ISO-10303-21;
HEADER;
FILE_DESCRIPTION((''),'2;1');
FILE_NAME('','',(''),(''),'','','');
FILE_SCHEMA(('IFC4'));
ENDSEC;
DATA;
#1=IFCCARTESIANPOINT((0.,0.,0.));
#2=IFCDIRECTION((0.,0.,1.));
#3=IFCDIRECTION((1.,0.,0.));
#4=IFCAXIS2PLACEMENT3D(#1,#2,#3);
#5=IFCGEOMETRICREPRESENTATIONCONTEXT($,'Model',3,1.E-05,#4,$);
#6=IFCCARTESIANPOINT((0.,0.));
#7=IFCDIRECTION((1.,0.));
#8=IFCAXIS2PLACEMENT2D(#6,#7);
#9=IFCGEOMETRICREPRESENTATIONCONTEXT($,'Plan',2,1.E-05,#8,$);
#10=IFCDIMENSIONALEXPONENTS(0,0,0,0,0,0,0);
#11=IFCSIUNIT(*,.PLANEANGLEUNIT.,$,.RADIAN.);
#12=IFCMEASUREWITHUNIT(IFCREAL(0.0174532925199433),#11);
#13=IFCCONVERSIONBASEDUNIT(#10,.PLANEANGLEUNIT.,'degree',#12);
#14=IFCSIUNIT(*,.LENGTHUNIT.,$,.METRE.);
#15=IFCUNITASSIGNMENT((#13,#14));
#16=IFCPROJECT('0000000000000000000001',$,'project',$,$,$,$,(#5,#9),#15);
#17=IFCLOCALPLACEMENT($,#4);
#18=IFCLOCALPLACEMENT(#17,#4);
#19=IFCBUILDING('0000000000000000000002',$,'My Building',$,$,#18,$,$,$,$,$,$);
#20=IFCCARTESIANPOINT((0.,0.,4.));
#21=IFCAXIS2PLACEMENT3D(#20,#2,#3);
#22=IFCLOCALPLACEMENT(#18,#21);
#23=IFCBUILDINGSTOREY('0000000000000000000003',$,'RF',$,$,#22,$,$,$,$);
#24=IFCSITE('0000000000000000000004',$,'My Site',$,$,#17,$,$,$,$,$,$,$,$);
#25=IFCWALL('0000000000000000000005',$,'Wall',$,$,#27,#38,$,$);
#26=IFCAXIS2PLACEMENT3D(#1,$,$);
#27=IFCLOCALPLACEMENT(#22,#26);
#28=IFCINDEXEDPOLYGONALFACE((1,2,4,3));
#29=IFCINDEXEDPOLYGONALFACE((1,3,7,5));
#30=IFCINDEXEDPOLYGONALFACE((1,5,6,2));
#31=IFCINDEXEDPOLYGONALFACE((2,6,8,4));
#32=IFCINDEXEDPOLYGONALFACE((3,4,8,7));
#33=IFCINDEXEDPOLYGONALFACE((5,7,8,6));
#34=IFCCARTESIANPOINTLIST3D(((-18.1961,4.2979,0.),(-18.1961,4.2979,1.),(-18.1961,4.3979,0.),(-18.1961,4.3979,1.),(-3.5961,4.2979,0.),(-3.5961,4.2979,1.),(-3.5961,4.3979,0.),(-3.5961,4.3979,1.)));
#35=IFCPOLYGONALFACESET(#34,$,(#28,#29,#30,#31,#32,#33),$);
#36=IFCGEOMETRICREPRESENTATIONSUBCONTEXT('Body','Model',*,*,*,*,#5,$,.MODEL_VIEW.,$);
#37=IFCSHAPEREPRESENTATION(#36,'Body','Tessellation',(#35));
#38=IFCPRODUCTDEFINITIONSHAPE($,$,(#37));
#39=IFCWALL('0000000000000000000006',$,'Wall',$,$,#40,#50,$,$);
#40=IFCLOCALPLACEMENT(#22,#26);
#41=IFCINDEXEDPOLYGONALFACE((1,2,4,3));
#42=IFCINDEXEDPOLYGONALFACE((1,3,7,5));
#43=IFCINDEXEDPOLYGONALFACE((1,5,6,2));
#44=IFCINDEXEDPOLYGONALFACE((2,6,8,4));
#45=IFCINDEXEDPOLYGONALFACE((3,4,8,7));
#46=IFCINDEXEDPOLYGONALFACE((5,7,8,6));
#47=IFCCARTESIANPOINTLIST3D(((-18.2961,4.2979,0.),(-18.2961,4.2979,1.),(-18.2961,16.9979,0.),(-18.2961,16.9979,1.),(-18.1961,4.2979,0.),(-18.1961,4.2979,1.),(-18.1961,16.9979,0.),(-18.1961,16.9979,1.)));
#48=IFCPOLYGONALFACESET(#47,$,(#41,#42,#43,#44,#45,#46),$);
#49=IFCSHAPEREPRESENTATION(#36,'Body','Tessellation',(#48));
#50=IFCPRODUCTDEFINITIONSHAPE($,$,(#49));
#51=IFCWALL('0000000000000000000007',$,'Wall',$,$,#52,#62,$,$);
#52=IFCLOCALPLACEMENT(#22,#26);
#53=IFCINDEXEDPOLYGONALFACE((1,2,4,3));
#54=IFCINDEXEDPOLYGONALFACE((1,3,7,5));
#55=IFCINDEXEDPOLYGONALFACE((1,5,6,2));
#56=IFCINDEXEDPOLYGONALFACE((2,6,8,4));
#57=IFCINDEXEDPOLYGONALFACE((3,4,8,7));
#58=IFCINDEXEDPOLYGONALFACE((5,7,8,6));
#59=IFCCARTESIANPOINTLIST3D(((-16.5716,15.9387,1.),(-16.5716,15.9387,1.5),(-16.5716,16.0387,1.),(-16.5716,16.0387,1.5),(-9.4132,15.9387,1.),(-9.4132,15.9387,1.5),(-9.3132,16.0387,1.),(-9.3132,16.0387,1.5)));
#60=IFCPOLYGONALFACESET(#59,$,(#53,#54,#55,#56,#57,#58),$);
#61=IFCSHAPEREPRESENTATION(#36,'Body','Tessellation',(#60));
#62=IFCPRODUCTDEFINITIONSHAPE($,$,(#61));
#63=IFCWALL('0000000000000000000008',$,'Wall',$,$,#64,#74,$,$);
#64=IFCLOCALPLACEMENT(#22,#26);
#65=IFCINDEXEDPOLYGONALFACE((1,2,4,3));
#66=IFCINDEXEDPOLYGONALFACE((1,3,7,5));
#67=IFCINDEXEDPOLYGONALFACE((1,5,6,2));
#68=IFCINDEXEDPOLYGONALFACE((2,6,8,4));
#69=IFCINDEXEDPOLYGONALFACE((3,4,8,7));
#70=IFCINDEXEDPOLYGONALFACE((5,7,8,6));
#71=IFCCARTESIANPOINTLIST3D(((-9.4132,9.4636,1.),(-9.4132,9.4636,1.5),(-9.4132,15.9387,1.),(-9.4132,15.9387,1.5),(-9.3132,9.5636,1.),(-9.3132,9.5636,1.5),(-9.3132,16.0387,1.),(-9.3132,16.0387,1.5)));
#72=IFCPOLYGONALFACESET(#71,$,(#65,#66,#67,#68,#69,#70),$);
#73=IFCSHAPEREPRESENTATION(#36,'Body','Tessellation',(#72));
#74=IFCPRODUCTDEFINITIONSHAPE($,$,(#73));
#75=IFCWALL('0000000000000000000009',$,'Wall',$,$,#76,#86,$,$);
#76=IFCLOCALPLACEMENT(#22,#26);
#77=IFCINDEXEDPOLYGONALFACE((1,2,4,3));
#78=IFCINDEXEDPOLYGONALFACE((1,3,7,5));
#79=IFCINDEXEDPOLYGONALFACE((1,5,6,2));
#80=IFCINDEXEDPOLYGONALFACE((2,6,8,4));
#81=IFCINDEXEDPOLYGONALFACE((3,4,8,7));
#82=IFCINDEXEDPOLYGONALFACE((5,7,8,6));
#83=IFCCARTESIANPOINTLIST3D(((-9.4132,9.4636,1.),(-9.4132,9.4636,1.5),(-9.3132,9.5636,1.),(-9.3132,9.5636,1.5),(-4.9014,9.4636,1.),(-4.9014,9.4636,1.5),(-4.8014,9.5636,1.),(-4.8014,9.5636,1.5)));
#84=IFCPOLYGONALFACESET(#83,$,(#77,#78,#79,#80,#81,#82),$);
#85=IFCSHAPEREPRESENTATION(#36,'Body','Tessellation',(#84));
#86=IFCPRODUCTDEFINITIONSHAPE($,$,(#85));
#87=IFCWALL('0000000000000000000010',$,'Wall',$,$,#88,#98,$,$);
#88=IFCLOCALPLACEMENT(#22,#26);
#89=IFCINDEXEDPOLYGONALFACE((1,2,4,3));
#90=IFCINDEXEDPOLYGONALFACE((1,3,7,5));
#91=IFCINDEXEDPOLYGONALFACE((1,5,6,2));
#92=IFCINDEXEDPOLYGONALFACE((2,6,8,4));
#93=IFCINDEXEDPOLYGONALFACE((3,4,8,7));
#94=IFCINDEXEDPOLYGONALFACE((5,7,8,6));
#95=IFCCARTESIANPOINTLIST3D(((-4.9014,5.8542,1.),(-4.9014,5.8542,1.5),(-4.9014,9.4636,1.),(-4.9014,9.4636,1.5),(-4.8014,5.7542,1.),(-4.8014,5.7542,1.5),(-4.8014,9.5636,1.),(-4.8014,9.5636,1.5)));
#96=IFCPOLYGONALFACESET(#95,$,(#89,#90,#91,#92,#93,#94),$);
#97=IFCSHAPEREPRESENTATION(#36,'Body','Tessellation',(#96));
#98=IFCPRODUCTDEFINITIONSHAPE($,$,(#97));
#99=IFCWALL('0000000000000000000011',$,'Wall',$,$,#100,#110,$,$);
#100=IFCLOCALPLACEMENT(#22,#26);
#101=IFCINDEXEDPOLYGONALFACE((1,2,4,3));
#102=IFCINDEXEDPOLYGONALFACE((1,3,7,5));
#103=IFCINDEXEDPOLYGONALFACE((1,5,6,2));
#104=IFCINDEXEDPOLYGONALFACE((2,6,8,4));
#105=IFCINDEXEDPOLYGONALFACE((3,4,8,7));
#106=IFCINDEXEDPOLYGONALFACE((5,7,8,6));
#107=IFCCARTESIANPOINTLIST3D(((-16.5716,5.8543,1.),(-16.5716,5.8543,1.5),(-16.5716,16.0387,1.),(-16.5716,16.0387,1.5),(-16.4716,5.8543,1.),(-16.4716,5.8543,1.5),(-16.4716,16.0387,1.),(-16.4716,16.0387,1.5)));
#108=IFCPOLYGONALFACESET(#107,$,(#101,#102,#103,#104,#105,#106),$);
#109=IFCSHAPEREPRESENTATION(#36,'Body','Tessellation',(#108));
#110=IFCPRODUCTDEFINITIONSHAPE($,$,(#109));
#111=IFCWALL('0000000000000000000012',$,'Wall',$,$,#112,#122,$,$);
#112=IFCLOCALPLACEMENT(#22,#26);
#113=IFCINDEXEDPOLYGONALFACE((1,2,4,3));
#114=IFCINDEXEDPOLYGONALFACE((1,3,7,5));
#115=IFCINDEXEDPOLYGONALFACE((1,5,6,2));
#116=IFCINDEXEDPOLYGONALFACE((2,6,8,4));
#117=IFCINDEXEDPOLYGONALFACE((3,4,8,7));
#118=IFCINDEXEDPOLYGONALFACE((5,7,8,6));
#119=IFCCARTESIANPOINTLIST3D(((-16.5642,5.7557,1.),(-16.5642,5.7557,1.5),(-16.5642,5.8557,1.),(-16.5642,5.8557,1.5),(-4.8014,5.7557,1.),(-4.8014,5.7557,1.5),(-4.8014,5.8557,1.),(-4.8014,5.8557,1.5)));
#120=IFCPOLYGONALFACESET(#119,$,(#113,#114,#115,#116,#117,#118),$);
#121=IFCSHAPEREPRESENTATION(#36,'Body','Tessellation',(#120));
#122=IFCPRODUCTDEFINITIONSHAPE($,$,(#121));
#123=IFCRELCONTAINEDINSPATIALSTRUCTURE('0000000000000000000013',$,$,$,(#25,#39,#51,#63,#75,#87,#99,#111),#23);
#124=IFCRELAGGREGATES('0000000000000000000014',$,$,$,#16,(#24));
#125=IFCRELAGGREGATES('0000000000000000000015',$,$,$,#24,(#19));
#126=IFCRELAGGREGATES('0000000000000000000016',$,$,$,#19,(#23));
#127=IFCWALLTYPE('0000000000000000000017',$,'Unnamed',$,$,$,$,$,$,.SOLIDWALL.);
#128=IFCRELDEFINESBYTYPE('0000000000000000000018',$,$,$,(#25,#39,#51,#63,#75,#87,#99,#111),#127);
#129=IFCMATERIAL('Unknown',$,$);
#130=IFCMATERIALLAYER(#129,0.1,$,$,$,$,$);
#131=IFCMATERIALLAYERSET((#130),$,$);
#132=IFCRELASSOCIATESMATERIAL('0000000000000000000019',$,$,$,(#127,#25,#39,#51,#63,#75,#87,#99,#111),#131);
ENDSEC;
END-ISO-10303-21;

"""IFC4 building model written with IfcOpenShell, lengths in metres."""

from ifc_helpers import new_model, entity, si_unit, converted_unit, frame, origin_with_axes, origin_2d_with_axis, place, context, subcontext, project, spatial, line, indexed_curve, outline, extrude, material, layer, layer_set, layer_usage, type_object, element, save


model = new_model("IFC4")

# Units and contexts
model_context = context("Model", 3, precision=1e-05, world=origin_with_axes())
plan_context = context("Plan", 2, precision=1e-05, world=origin_2d_with_axis())
body_context = subcontext(model_context, "Body", "Model", "MODEL_VIEW")
ifc_project = project(units=[converted_unit("PLANEANGLEUNIT", "degree", entity("IfcReal", 0.0174532925199433), si_unit("PLANEANGLEUNIT", "RADIAN"), dimensions=[0, 0, 0, 0, 0, 0, 0]), si_unit("LENGTHUNIT", "METRE")], contexts=[model_context, plan_context])

# Site, building, storey
site_placement = place(None, origin_with_axes())
site = spatial("IfcSite", under=ifc_project, at=site_placement, Name="My Site")
building_placement = place(site_placement, origin_with_axes())
building = spatial("IfcBuilding", under=site, at=building_placement, Name="My Building")
storey_placement = place(building_placement, frame((0.0, 0.0, 4.0), z_axis=(0.0, 0.0, 1.0), x_axis=(1.0, 0.0, 0.0)))
storey = spatial("IfcBuildingStorey", under=building, at=storey_placement, Name="RF")

# Shared definitions
ifc_material = material(Name="Unknown")

# Walls
ifc_layer_1 = layer(ifc_material, 0.1)
ifc_layer_set_1 = layer_set([ifc_layer_1])
wall_type = type_object("IfcWallType", Name="Unnamed", PredefinedType="SOLIDWALL", material=ifc_layer_set_1)
ifc_layer_usage_1 = layer_usage(ifc_layer_set_1, "AXIS2", "POSITIVE", 0.0)
wall_1_placement = place(storey_placement, frame((-18.1961, 4.2979, 0.0), z_axis=(0.0, 0.0, 1.0), x_axis=(1.0, 0.0, 0.0)))
element("IfcWall", 1, at=wall_1_placement, inside=storey, type_object=wall_type, material=ifc_layer_usage_1, Name="Wall", context=body_context, shape_type="SweptSolid", body=[
    extrude(outline(indexed_curve([(0.0, 0.0), (0.0, 0.1), (14.6, 0.1), (14.6, 0.0)], segments=[line(1, 2, 3, 4, 1)])), origin_with_axes(), (0.0, 0.0, 1.0), 1.0),
])
ifc_layer_usage_2 = layer_usage(ifc_layer_set_1, "AXIS2", "POSITIVE", 0.0)
wall_2_placement = place(storey_placement, frame((-18.2961, 16.9979, 0.0), z_axis=(0.0, 0.0, 1.0), x_axis=(0.0, -1.0, 0.0)))
element("IfcWall", 2, at=wall_2_placement, inside=storey, type_object=wall_type, material=ifc_layer_usage_2, Name="Wall", context=body_context, shape_type="SweptSolid", body=[
    extrude(outline(indexed_curve([(0.0, 0.0), (0.0, 0.1), (12.7, 0.1), (12.7, 0.0)], segments=[line(1, 2, 3, 4, 1)])), origin_with_axes(), (0.0, 0.0, 1.0), 1.0),
])
ifc_layer_usage_3 = layer_usage(ifc_layer_set_1, "AXIS2", "POSITIVE", 0.0)
wall_3_placement = place(storey_placement, frame((-16.5716, 15.9387, 1.0), z_axis=(0.0, 0.0, 1.0), x_axis=(1.0, 0.0, 0.0)))
element("IfcWall", 3, at=wall_3_placement, inside=storey, type_object=wall_type, material=ifc_layer_usage_3, Name="Wall", context=body_context, shape_type="SweptSolid", body=[
    extrude(outline(indexed_curve([(0.0, 0.0), (0.0, 0.1), (7.2584, 0.1), (7.1584, 0.0)], segments=[line(1, 2, 3, 4, 1)])), origin_with_axes(), (0.0, 0.0, 1.0), 0.5),
])
ifc_layer_usage_4 = layer_usage(ifc_layer_set_1, "AXIS2", "POSITIVE", 0.0)
wall_4_placement = place(storey_placement, frame((-9.4132, 15.9387, 1.0), z_axis=(0.0, 0.0, 1.0), x_axis=(0.0, -1.0, 0.0)))
element("IfcWall", 4, at=wall_4_placement, inside=storey, type_object=wall_type, material=ifc_layer_usage_4, Name="Wall", context=body_context, shape_type="SweptSolid", body=[
    extrude(outline(indexed_curve([(0.0, 0.0), (-0.1, 0.1), (6.3751, 0.1), (6.4751, 0.0)], segments=[line(1, 2, 3, 4, 1)])), origin_with_axes(), (0.0, 0.0, 1.0), 0.5),
])
ifc_layer_usage_5 = layer_usage(ifc_layer_set_1, "AXIS2", "POSITIVE", 0.0)
wall_5_placement = place(storey_placement, frame((-9.4132, 9.4636, 1.0), z_axis=(0.0, 0.0, 1.0), x_axis=(1.0, 0.0, 0.0)))
element("IfcWall", 5, at=wall_5_placement, inside=storey, type_object=wall_type, material=ifc_layer_usage_5, Name="Wall", context=body_context, shape_type="SweptSolid", body=[
    extrude(outline(indexed_curve([(0.0, 0.0), (0.1, 0.1), (4.6118, 0.1), (4.5118, 0.0)], segments=[line(1, 2, 3, 4, 1)])), origin_with_axes(), (0.0, 0.0, 1.0), 0.5),
])
ifc_layer_usage_6 = layer_usage(ifc_layer_set_1, "AXIS2", "POSITIVE", 0.0)
wall_6_placement = place(storey_placement, frame((-4.9014, 9.4636, 1.0), z_axis=(0.0, 0.0, 1.0), x_axis=(0.0, -1.0, 0.0)))
element("IfcWall", 6, at=wall_6_placement, inside=storey, type_object=wall_type, material=ifc_layer_usage_6, Name="Wall", context=body_context, shape_type="SweptSolid", body=[
    extrude(outline(indexed_curve([(0.0, 0.0), (-0.1, 0.1), (3.7093, 0.1), (3.6093, 0.0)], segments=[line(1, 2, 3, 4, 1)])), origin_with_axes(), (0.0, 0.0, 1.0), 0.5),
])
ifc_layer_usage_7 = layer_usage(ifc_layer_set_1, "AXIS2", "POSITIVE", 0.0)
wall_7_placement = place(storey_placement, frame((-16.5716, 16.0387, 1.0), z_axis=(0.0, 0.0, 1.0), x_axis=(0.0, -1.0, 0.0)))
element("IfcWall", 7, at=wall_7_placement, inside=storey, type_object=wall_type, material=ifc_layer_usage_7, Name="Wall", context=body_context, shape_type="SweptSolid", body=[
    extrude(outline(indexed_curve([(0.0, 0.0), (0.0, 0.1), (10.1844, 0.1), (10.1844, 0.0)], segments=[line(1, 2, 3, 4, 1)])), origin_with_axes(), (0.0, 0.0, 1.0), 0.5),
])
ifc_layer_usage_8 = layer_usage(ifc_layer_set_1, "AXIS2", "POSITIVE", 0.0)
wall_8_placement = place(storey_placement, frame((-16.5642, 5.7557, 1.0), z_axis=(0.0, 0.0, 1.0), x_axis=(1.0, 0.0, 0.0)))
element("IfcWall", 8, at=wall_8_placement, inside=storey, type_object=wall_type, material=ifc_layer_usage_8, Name="Wall", context=body_context, shape_type="SweptSolid", body=[
    extrude(outline(indexed_curve([(0.0, 0.0), (0.0, 0.1), (11.7629, 0.1), (11.7629, 0.0)], segments=[line(1, 2, 3, 4, 1)])), origin_with_axes(), (0.0, 0.0, 1.0), 0.5),
])

save(model, "model.ifc")
